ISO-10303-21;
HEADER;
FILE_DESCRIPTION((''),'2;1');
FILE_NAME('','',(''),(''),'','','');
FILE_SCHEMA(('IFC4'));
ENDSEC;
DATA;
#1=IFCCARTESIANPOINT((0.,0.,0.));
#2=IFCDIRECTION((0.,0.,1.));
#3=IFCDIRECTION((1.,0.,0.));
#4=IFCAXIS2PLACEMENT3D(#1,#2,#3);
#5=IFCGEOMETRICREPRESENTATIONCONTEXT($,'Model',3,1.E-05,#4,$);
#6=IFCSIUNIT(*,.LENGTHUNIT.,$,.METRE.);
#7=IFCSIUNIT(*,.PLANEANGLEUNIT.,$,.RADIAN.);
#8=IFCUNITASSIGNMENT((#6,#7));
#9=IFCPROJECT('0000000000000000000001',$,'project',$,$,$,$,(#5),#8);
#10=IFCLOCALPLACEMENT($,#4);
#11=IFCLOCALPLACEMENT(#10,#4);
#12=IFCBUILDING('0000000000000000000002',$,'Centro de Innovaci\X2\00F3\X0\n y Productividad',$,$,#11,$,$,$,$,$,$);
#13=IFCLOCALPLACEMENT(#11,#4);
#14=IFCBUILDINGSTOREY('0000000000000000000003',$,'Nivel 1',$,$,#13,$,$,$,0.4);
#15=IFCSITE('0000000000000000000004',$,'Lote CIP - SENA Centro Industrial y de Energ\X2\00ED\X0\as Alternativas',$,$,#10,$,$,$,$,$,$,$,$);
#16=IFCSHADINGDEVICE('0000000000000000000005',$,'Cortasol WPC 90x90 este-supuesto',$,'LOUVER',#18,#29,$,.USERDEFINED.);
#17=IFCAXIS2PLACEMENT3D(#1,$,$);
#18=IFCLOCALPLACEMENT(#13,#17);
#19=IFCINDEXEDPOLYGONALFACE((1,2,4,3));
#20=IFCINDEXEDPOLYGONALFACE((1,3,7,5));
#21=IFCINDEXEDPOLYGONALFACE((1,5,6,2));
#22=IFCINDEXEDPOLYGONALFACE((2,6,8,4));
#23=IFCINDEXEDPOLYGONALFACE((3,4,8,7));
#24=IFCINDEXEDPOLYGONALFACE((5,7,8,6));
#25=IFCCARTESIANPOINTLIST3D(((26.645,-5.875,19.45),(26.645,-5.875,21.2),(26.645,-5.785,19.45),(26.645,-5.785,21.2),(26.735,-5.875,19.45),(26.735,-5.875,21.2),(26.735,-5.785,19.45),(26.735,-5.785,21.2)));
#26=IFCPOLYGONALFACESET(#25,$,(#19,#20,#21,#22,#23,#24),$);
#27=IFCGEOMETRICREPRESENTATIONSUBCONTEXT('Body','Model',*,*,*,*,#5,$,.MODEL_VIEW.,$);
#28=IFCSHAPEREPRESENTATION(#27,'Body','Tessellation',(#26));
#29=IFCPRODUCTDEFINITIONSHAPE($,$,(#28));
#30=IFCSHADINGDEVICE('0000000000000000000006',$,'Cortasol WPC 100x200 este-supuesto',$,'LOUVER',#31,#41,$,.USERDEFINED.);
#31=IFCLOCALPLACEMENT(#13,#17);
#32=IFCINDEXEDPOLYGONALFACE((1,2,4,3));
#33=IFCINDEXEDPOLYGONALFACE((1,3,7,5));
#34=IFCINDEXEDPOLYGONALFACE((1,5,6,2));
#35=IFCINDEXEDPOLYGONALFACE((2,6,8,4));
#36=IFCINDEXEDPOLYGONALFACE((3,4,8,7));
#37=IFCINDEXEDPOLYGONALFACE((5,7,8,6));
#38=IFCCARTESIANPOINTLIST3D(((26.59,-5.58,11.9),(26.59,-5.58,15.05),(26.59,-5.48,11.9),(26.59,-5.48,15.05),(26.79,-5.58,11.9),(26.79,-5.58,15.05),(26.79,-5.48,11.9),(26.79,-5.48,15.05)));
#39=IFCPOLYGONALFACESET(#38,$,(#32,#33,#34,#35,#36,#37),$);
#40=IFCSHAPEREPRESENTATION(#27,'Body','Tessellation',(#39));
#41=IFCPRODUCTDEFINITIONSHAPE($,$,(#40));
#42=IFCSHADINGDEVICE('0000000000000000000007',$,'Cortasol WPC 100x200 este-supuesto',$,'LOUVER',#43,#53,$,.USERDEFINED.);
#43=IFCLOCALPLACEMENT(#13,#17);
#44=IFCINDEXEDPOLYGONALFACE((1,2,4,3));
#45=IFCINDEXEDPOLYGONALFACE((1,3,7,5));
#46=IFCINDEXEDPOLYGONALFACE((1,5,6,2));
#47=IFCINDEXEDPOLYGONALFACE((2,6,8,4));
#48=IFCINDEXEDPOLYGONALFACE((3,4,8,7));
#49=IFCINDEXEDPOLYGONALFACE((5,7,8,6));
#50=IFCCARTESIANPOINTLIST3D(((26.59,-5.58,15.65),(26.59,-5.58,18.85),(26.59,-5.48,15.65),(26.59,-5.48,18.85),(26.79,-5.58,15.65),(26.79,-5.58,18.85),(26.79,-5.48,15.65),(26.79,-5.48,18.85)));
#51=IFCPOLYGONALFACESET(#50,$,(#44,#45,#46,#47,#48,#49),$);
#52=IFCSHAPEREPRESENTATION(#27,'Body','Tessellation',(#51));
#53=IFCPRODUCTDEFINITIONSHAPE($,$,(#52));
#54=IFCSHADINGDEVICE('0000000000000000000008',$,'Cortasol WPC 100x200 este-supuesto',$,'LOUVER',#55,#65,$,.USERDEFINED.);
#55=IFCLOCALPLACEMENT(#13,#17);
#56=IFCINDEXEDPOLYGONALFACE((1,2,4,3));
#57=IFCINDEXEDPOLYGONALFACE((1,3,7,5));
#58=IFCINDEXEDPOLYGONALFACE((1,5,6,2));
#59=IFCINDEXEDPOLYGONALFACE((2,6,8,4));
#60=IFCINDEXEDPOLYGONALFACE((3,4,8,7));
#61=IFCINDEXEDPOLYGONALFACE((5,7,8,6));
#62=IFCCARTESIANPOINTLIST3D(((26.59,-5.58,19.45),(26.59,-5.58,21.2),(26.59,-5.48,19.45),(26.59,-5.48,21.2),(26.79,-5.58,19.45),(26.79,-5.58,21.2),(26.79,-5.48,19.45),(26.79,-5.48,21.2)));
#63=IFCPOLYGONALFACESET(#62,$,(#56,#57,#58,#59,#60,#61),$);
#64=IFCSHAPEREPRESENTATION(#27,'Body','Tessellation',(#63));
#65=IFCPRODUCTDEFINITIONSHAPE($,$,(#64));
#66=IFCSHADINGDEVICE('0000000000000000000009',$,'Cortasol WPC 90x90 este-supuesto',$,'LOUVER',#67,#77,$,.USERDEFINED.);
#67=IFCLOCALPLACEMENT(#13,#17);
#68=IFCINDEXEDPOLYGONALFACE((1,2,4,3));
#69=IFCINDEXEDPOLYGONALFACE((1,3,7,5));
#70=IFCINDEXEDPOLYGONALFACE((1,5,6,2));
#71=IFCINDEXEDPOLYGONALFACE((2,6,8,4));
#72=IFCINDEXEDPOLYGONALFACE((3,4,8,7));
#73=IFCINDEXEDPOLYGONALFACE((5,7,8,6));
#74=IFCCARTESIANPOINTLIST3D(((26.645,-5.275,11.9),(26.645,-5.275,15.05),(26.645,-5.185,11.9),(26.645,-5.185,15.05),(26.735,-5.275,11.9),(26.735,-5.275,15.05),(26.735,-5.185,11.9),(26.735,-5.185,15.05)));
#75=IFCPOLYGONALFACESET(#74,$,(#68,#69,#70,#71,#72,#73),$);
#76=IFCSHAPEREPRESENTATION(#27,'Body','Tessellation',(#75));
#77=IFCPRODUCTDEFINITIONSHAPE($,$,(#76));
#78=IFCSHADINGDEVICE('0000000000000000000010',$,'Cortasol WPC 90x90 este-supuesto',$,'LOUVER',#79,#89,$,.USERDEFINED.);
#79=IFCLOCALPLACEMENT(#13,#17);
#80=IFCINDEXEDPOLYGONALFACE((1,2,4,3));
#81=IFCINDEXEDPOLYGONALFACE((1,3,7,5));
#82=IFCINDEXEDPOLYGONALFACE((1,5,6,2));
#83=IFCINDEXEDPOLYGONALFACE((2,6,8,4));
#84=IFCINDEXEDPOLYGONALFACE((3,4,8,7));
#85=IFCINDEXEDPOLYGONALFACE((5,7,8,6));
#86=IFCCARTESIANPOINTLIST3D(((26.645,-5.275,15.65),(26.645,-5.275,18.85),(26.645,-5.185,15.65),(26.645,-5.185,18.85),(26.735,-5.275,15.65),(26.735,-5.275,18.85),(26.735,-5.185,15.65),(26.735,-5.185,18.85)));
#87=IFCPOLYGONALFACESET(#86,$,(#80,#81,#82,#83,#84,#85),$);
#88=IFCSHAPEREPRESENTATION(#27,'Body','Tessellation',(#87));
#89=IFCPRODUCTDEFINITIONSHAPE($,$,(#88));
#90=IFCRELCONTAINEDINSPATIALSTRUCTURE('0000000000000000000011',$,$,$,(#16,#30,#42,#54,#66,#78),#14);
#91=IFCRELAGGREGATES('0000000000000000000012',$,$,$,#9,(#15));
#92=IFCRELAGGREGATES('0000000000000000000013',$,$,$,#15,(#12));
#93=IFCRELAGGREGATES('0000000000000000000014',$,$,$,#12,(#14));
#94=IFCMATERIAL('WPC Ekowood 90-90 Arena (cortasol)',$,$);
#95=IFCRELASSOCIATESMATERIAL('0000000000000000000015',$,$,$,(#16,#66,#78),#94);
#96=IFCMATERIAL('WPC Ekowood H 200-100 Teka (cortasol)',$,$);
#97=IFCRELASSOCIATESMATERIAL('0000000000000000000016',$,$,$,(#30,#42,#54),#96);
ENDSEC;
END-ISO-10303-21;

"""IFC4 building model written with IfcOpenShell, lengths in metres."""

from ifc_helpers import new_model, si_unit, frame, origin_with_axes, place, context, subcontext, project, spatial, polyline, outline, extrude, material, element, save


model = new_model("IFC4")

# Units and contexts
model_context = context("Model", 3, precision=1e-05, world=origin_with_axes())
body_context = subcontext(model_context, "Body", "Model", "MODEL_VIEW")
ifc_project = project(units=[si_unit("LENGTHUNIT", "METRE"), si_unit("PLANEANGLEUNIT", "RADIAN")], contexts=[model_context])

# Site, building, storey
site_placement = place(None, origin_with_axes())
site = spatial("IfcSite", under=ifc_project, at=site_placement, Name="Lote CIP - SENA Centro Industrial y de Energías Alternativas")
building_placement = place(site_placement, origin_with_axes())
building = spatial("IfcBuilding", under=site, at=building_placement, Name="Centro de Innovación y Productividad")
storey_placement = place(building_placement, origin_with_axes())
storey = spatial("IfcBuildingStorey", under=building, at=storey_placement, Name="Nivel 1", Elevation=0.4)

# Shading devices
ifc_material_1 = material(Name="WPC Ekowood H 200-100 Teka (cortasol)")
ifc_material_2 = material(Name="WPC Ekowood 90-90 Arena (cortasol)")
shading_device_1_placement = place(storey_placement, origin_with_axes())
element("IfcShadingDevice", 1, at=shading_device_1_placement, inside=storey, material=ifc_material_2, Name="Cortasol WPC 90x90 este-supuesto", ObjectType="LOUVER", PredefinedType="USERDEFINED", context=body_context, shape_type="SweptSolid", body=[
    extrude(outline(polyline([(26.735, -5.875), (26.645, -5.875), (26.645, -5.785), (26.735, -5.785), (26.735, -5.875)])), frame((0.0, 0.0, 19.45)), (0.0, 0.0, 1.0), 1.75),
])
shading_device_2_placement = place(storey_placement, origin_with_axes())
element("IfcShadingDevice", 2, at=shading_device_2_placement, inside=storey, material=ifc_material_1, Name="Cortasol WPC 100x200 este-supuesto", ObjectType="LOUVER", PredefinedType="USERDEFINED", context=body_context, shape_type="SweptSolid", body=[
    extrude(outline(polyline([(26.79, -5.58), (26.59, -5.58), (26.59, -5.48), (26.79, -5.48), (26.79, -5.58)])), frame((0.0, 0.0, 11.9)), (0.0, 0.0, 1.0), 3.15),
])
shading_device_3_placement = place(storey_placement, origin_with_axes())
element("IfcShadingDevice", 3, at=shading_device_3_placement, inside=storey, material=ifc_material_1, Name="Cortasol WPC 100x200 este-supuesto", ObjectType="LOUVER", PredefinedType="USERDEFINED", context=body_context, shape_type="SweptSolid", body=[
    extrude(outline(polyline([(26.79, -5.58), (26.59, -5.58), (26.59, -5.48), (26.79, -5.48), (26.79, -5.58)])), frame((0.0, 0.0, 15.65)), (0.0, 0.0, 1.0), 3.2),
])
shading_device_4_placement = place(storey_placement, origin_with_axes())
element("IfcShadingDevice", 4, at=shading_device_4_placement, inside=storey, material=ifc_material_1, Name="Cortasol WPC 100x200 este-supuesto", ObjectType="LOUVER", PredefinedType="USERDEFINED", context=body_context, shape_type="SweptSolid", body=[
    extrude(outline(polyline([(26.79, -5.58), (26.59, -5.58), (26.59, -5.48), (26.79, -5.48), (26.79, -5.58)])), frame((0.0, 0.0, 19.45)), (0.0, 0.0, 1.0), 1.75),
])
shading_device_5_placement = place(storey_placement, origin_with_axes())
element("IfcShadingDevice", 5, at=shading_device_5_placement, inside=storey, material=ifc_material_2, Name="Cortasol WPC 90x90 este-supuesto", ObjectType="LOUVER", PredefinedType="USERDEFINED", context=body_context, shape_type="SweptSolid", body=[
    extrude(outline(polyline([(26.735, -5.275), (26.645, -5.275), (26.645, -5.185), (26.735, -5.185), (26.735, -5.275)])), frame((0.0, 0.0, 11.9)), (0.0, 0.0, 1.0), 3.15),
])
shading_device_6_placement = place(storey_placement, origin_with_axes())
element("IfcShadingDevice", 6, at=shading_device_6_placement, inside=storey, material=ifc_material_2, Name="Cortasol WPC 90x90 este-supuesto", ObjectType="LOUVER", PredefinedType="USERDEFINED", context=body_context, shape_type="SweptSolid", body=[
    extrude(outline(polyline([(26.735, -5.275), (26.645, -5.275), (26.645, -5.185), (26.735, -5.185), (26.735, -5.275)])), frame((0.0, 0.0, 15.65)), (0.0, 0.0, 1.0), 3.2),
])

save(model, "model.ifc")
